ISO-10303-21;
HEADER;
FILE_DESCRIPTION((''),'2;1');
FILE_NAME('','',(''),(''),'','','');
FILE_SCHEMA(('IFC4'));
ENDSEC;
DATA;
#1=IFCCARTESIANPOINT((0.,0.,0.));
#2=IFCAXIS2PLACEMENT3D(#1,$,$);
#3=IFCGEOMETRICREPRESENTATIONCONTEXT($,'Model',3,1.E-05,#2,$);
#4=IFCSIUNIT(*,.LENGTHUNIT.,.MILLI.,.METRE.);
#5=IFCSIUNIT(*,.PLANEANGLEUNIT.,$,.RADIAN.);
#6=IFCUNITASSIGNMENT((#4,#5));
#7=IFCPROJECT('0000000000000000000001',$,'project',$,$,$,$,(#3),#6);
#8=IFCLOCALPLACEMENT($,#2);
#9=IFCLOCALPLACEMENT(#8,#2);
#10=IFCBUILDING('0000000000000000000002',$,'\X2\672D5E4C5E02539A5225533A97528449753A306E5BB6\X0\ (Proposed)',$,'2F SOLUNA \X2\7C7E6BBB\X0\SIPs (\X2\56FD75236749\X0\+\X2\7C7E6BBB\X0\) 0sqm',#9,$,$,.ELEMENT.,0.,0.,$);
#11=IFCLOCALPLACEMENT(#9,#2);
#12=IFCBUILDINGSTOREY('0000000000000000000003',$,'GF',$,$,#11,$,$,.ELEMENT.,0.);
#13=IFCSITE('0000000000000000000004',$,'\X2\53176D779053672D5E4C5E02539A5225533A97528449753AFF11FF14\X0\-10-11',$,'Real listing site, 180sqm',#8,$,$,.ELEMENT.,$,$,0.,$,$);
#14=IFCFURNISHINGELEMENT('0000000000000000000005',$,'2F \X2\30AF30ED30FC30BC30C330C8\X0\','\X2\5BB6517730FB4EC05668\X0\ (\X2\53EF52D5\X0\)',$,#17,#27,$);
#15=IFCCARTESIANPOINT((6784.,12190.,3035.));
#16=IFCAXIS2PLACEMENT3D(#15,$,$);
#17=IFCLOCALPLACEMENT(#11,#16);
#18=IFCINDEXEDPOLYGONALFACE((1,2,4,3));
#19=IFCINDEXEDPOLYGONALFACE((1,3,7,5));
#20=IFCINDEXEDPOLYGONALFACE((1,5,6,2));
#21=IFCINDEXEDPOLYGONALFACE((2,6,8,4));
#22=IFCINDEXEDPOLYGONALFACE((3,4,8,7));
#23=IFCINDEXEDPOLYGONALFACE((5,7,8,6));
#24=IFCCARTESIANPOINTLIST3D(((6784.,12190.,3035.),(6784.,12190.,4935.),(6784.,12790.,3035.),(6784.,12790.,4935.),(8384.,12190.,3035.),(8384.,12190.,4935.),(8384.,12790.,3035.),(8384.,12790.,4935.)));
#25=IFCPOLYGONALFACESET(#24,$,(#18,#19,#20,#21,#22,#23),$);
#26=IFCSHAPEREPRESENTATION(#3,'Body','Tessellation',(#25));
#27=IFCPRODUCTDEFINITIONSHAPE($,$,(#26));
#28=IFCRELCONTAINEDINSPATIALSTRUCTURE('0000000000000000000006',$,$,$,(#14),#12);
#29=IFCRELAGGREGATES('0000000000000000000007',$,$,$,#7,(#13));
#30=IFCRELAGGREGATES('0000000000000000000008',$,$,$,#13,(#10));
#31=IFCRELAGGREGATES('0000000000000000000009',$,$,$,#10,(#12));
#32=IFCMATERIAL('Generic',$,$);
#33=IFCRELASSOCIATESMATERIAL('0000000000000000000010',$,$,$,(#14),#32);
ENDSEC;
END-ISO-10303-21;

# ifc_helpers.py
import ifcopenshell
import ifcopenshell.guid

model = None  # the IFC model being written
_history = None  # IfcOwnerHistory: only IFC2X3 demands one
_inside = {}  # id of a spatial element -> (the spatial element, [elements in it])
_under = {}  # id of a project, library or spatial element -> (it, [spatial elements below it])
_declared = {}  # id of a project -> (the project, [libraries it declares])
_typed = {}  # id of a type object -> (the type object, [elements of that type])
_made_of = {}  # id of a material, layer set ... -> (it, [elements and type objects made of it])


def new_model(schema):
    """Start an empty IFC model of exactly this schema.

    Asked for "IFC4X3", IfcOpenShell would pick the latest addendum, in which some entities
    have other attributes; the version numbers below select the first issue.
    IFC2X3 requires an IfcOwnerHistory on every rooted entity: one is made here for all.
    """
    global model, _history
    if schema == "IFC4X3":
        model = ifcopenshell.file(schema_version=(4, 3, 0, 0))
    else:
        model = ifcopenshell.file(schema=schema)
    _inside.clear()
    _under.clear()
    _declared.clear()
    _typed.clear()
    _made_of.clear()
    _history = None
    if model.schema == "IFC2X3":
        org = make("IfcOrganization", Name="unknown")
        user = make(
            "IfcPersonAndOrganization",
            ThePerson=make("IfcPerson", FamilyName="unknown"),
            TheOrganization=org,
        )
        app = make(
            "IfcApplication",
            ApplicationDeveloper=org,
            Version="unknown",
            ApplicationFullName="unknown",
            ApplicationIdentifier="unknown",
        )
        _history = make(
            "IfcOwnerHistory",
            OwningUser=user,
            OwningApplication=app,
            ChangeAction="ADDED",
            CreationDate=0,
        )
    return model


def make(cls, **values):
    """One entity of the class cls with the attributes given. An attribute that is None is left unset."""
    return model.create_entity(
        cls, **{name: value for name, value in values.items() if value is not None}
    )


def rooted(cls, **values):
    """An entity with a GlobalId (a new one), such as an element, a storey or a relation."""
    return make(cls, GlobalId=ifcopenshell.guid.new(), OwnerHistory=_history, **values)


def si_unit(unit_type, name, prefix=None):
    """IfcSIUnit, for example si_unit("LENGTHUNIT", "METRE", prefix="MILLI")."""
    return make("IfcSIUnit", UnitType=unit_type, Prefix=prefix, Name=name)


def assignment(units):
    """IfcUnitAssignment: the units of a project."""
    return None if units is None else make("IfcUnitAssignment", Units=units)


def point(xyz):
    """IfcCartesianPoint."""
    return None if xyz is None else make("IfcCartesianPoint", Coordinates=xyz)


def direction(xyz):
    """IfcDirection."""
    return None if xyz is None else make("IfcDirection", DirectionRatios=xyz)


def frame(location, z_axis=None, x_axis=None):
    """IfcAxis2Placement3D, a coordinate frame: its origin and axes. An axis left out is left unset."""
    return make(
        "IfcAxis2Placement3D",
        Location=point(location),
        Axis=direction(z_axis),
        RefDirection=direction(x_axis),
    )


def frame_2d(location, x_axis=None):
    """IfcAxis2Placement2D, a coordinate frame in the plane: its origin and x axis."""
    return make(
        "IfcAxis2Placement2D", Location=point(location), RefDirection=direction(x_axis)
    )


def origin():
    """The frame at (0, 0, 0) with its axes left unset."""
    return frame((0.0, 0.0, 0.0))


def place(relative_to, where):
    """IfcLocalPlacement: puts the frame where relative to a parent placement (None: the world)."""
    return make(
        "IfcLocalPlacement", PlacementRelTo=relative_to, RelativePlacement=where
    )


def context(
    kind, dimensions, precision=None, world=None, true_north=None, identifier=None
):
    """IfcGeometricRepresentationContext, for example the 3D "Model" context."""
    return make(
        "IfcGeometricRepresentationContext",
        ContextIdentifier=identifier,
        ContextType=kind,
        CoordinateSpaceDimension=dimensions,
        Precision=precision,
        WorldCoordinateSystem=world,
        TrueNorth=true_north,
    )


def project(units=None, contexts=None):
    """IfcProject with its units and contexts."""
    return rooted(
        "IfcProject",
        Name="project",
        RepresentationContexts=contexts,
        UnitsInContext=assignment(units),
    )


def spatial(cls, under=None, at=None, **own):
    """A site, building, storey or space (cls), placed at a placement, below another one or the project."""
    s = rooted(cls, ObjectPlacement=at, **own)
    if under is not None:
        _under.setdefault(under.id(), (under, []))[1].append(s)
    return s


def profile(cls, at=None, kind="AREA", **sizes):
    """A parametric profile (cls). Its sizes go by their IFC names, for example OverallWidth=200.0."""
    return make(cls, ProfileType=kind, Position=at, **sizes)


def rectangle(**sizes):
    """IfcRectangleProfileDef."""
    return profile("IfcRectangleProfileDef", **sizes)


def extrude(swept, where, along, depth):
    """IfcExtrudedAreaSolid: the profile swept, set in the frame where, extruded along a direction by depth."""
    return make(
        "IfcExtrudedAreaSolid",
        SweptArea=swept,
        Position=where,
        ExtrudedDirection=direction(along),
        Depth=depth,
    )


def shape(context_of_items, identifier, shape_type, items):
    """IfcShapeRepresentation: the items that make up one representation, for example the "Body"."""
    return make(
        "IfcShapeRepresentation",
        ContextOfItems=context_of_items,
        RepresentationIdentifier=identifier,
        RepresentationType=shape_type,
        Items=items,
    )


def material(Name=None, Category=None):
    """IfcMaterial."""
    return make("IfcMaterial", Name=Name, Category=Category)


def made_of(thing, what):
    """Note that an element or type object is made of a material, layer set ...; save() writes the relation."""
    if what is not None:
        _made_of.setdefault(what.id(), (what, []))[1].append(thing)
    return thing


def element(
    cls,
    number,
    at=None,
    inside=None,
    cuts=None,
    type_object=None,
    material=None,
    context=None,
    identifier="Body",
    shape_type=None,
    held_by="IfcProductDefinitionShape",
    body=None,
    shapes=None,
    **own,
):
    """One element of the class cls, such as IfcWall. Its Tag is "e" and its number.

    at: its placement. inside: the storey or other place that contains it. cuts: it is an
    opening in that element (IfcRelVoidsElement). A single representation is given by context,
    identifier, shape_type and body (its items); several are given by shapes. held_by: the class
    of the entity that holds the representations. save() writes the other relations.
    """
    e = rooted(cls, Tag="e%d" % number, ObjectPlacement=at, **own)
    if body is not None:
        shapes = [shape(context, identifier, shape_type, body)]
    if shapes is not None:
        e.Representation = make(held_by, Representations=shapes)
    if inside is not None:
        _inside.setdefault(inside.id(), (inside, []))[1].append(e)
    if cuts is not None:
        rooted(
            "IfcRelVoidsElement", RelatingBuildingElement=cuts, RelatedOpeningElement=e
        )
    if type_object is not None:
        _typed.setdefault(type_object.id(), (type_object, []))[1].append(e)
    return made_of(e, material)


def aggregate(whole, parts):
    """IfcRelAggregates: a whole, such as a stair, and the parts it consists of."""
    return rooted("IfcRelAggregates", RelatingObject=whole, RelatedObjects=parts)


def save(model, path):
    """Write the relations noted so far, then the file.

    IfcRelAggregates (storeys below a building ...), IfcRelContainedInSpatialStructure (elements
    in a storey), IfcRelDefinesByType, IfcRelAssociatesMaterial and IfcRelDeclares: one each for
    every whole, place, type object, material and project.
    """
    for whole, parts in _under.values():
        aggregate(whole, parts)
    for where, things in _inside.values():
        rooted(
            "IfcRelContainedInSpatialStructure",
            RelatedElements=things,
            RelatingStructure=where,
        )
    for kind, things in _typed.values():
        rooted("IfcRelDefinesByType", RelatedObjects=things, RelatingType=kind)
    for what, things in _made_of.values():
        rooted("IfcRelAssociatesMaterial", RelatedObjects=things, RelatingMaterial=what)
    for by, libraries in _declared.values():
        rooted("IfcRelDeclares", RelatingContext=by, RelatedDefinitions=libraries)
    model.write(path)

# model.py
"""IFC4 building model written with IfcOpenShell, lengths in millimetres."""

from ifc_helpers import new_model, si_unit, frame, frame_2d, origin, place, context, project, spatial, rectangle, extrude, material, element, save


model = new_model("IFC4")

# Units and contexts
model_context = context("Model", 3, precision=1e-05, world=origin())
ifc_project = project(units=[si_unit("LENGTHUNIT", "METRE", prefix="MILLI"), si_unit("PLANEANGLEUNIT", "RADIAN")], contexts=[model_context])

# Site, building, storey
site_placement = place(None, origin())
site = spatial("IfcSite", under=ifc_project, at=site_placement, Name="北海道札幌市厚別区青葉町１４-10-11", ObjectType="Real listing site, 180sqm", CompositionType="ELEMENT", RefElevation=0.0)
building_placement = place(site_placement, origin())
building = spatial("IfcBuilding", under=site, at=building_placement, Name="札幌市厚別区青葉町の家 (Proposed)", ObjectType="2F SOLUNA 籾殻SIPs (国産杉+籾殻) 0sqm", CompositionType="ELEMENT", ElevationOfRefHeight=0.0, ElevationOfTerrain=0.0)
storey_placement = place(building_placement, origin())
storey = spatial("IfcBuildingStorey", under=building, at=storey_placement, Name="GF", CompositionType="ELEMENT", Elevation=0.0)

# Shared definitions
ifc_material_1 = material(Name="Generic")

# Furnishing element
furnishing_1_placement = place(storey_placement, frame((6784.0, 12190.0, 3035.0)))
element("IfcFurnishingElement", 1, at=furnishing_1_placement, inside=storey, material=ifc_material_1, Name="2F クローゼット", Description="家具・什器 (可動)", context=model_context, shape_type="SweptSolid", body=[
    extrude(rectangle(XDim=1600.0, YDim=600.0, at=frame_2d((800.0, 300.0))), frame((6784.0, 12190.0, 3035.0)), (0.0, 0.0, 1.0), 1900.0),
])

save(model, "model.ifc")
